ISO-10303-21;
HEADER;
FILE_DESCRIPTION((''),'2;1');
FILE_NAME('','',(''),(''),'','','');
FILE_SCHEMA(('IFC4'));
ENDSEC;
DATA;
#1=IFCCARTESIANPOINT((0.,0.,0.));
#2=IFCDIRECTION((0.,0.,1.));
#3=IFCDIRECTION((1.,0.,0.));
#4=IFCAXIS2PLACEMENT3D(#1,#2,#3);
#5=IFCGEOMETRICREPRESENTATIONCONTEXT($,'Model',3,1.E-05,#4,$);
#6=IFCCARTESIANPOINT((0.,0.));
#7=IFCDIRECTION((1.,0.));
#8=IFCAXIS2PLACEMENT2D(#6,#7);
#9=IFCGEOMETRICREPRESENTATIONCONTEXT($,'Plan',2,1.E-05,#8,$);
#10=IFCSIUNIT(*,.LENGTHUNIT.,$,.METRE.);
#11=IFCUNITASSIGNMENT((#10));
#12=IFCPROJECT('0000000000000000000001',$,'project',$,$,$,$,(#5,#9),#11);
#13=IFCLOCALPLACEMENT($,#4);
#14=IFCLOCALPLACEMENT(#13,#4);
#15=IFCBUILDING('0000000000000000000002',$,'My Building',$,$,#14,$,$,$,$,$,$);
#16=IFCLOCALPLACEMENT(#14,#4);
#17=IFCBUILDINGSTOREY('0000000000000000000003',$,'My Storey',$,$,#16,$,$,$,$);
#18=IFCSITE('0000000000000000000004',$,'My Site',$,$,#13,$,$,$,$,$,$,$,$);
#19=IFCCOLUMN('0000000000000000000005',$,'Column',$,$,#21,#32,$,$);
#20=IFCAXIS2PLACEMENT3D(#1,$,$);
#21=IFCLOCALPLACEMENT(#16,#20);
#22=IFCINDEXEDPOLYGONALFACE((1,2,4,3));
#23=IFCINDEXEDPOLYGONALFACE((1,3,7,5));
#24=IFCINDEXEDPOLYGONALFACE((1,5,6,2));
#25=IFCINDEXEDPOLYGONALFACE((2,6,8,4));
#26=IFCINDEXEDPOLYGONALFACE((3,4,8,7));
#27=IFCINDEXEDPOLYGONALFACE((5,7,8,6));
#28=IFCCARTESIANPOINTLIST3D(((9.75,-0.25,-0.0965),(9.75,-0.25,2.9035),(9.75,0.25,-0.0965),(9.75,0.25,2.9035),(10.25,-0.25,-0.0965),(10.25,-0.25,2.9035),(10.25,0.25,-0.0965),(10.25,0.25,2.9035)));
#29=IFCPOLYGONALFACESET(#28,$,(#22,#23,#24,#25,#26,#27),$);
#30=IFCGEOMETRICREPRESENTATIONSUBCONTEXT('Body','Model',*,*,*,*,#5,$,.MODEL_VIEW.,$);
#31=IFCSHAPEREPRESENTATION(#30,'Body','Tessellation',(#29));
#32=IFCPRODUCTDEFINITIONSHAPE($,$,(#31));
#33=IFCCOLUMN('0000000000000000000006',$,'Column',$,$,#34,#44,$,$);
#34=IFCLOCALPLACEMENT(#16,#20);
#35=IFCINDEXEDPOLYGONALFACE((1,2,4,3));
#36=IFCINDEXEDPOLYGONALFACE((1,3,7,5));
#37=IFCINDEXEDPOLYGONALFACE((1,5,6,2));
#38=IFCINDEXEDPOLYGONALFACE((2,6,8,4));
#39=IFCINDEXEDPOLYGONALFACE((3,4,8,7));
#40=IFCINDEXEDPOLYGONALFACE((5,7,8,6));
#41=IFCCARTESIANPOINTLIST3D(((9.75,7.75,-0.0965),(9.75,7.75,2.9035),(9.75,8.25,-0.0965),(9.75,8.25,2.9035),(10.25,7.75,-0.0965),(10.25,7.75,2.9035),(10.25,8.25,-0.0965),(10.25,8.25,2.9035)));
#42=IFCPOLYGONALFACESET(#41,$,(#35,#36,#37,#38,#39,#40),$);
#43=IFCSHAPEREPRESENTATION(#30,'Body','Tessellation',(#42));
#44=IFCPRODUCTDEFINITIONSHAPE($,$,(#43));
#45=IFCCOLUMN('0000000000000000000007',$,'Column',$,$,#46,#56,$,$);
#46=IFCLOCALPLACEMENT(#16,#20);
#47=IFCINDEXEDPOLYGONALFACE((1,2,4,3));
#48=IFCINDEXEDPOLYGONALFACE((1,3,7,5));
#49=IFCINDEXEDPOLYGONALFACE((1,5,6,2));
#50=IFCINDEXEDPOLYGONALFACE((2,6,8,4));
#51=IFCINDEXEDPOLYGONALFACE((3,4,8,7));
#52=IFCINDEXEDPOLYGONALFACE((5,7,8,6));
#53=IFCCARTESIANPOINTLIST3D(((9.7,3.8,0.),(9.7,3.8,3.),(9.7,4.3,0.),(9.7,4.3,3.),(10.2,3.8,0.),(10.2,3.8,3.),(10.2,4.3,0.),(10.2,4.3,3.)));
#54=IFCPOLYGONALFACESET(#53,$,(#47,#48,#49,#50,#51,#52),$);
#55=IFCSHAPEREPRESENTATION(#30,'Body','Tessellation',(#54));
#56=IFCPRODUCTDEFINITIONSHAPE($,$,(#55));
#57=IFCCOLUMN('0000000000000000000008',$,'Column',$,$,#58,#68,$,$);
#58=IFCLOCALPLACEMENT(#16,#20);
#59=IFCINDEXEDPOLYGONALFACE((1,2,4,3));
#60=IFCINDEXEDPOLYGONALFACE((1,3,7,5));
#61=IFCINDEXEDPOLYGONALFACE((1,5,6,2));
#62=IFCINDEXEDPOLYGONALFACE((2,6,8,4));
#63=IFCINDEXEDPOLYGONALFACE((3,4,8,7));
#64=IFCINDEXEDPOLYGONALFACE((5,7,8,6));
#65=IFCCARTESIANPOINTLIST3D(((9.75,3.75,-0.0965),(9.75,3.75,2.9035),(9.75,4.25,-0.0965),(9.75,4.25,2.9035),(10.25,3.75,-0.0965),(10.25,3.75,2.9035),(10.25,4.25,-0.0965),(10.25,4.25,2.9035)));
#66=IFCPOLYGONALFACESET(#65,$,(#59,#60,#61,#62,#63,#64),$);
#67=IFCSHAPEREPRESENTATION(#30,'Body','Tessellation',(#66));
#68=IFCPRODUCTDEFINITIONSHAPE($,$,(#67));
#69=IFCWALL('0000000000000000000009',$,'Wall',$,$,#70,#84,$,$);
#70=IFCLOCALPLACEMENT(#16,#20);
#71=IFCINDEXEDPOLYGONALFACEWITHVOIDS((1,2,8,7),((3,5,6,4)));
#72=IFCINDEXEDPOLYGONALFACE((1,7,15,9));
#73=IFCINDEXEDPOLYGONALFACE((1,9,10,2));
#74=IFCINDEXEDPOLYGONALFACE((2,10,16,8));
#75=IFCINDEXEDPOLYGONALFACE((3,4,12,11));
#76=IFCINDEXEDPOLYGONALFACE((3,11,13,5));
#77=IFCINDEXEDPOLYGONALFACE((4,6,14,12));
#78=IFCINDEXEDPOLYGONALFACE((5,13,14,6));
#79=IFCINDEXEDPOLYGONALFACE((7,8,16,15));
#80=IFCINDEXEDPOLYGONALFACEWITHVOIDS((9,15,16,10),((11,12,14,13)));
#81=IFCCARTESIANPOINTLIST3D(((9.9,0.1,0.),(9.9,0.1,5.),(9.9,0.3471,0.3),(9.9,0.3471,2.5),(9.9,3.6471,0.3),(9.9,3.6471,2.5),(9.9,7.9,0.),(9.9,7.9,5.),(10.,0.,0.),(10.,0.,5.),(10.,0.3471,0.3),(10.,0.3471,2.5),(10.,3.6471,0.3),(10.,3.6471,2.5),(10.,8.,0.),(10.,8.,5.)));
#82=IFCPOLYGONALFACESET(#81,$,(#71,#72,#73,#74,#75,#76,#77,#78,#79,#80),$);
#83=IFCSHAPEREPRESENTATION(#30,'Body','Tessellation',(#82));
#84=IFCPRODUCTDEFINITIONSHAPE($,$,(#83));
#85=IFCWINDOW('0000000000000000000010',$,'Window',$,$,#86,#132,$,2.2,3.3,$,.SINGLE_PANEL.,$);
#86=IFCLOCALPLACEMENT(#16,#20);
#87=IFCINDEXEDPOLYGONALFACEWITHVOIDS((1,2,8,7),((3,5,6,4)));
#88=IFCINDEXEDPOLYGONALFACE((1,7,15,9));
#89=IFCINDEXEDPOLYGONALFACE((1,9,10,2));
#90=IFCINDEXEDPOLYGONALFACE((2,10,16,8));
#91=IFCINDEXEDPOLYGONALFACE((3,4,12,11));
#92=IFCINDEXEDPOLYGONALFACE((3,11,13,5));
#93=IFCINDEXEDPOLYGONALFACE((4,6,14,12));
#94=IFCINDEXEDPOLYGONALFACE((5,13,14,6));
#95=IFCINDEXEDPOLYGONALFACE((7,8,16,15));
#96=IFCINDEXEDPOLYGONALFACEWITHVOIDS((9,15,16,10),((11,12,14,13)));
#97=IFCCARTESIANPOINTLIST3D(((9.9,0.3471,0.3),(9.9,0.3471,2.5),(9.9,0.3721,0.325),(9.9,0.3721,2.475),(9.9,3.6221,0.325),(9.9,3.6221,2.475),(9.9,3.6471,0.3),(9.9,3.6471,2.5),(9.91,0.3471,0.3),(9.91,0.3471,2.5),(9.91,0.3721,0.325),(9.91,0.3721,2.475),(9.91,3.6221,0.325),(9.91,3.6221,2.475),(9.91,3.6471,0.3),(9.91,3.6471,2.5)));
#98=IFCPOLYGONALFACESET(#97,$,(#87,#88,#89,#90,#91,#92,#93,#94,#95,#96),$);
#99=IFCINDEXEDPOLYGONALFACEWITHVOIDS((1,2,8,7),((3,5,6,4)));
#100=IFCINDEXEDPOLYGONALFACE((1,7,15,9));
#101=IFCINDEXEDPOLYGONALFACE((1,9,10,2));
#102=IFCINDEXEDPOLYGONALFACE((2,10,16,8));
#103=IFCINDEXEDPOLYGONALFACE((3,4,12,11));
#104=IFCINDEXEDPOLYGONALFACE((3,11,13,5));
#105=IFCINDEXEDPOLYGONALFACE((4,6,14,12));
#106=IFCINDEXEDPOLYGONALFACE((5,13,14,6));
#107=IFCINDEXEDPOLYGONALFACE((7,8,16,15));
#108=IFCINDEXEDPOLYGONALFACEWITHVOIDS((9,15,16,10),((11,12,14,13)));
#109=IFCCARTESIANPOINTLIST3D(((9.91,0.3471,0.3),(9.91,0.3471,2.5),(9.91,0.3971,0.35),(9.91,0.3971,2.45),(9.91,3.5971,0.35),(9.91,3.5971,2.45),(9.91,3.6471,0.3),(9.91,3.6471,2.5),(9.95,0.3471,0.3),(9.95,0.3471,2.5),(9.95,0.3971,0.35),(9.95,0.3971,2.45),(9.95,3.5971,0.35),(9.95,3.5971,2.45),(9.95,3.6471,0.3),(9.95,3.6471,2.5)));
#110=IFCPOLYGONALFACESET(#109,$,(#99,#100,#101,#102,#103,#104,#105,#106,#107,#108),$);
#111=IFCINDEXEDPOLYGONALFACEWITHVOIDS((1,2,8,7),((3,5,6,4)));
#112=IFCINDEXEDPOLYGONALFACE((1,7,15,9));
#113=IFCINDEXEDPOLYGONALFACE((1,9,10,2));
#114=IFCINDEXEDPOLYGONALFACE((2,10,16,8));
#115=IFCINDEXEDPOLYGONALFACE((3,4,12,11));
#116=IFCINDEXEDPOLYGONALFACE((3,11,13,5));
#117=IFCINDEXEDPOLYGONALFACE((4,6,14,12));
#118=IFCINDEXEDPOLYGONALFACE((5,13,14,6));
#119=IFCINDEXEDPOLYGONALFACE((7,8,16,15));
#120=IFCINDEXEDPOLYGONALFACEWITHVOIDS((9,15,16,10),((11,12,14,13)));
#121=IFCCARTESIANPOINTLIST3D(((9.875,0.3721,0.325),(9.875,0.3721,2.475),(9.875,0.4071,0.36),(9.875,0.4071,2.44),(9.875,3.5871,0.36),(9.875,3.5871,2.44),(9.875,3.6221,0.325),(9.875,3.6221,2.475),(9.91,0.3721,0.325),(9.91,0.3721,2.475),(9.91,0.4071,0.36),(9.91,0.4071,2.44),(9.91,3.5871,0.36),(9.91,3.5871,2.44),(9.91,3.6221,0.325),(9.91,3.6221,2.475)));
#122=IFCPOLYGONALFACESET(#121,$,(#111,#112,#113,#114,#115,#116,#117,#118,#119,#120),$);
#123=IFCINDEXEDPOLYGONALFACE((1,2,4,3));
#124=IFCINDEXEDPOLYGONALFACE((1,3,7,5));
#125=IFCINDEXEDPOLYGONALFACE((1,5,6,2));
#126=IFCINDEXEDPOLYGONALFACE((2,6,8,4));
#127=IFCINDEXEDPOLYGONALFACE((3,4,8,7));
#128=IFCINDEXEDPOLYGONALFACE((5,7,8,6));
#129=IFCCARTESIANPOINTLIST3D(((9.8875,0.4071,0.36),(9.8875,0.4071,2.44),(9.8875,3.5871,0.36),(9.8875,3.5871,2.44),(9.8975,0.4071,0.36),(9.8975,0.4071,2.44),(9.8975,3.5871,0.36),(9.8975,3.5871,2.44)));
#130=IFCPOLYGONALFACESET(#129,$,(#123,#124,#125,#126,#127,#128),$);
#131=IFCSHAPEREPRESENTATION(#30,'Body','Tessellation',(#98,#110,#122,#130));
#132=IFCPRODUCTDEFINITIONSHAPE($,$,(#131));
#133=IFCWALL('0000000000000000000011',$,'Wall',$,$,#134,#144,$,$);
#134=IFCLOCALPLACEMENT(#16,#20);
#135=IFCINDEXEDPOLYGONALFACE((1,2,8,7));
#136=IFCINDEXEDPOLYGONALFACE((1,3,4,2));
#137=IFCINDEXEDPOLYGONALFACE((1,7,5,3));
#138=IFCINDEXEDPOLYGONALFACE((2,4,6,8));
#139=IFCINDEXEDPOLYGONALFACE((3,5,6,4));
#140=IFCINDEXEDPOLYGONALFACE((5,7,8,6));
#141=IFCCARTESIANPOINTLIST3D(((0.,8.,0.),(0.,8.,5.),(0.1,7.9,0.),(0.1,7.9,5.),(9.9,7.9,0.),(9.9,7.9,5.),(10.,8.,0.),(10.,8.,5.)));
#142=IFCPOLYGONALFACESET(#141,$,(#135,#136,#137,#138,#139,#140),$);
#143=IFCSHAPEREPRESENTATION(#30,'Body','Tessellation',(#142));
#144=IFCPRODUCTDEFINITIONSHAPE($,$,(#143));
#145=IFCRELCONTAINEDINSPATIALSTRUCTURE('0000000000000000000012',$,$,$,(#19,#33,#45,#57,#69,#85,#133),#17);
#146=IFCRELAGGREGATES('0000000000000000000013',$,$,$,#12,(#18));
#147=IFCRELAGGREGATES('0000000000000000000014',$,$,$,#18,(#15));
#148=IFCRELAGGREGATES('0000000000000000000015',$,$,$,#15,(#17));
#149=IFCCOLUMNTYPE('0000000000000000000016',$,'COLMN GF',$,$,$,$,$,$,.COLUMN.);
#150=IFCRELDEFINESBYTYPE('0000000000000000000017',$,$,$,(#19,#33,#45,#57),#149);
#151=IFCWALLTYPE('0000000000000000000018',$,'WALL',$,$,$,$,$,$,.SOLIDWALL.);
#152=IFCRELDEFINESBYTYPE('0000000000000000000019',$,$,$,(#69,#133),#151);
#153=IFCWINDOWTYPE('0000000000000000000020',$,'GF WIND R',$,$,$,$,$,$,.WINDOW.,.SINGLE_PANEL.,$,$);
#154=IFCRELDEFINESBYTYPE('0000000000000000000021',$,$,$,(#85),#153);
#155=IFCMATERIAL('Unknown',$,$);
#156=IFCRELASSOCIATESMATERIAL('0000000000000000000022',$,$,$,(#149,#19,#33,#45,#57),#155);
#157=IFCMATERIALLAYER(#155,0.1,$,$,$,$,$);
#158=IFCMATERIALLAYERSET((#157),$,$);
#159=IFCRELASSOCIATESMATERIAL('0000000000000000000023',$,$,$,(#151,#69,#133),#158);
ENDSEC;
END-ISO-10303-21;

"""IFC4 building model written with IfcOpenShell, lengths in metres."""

from ifc_helpers import new_model, entity, si_unit, frame, origin_with_axes, origin_2d_with_axis, place, context, subcontext, project, spatial, line, indexed_curve, rectangle, outline, extrude, shape, source, transform, mapped, material, layer, layer_set, layer_usage, material_profile, profile_set, profile_usage, type_object, type_shapes, element, fill, save


model = new_model("IFC4")

# Units and contexts
model_context = context("Model", 3, precision=1e-05, world=origin_with_axes())
plan_context = context("Plan", 2, precision=1e-05, world=origin_2d_with_axis())
body_context_1 = subcontext(model_context, "Body", "Model", "MODEL_VIEW")
body_context_2 = subcontext(plan_context, "Body", "Plan", "PLAN_VIEW")
ifc_project = project(units=[si_unit("LENGTHUNIT", "METRE")], contexts=[model_context, plan_context])

# Site, building, storey
site_placement = place(None, origin_with_axes())
site = spatial("IfcSite", under=ifc_project, at=site_placement, Name="My Site")
building_placement = place(site_placement, origin_with_axes())
building = spatial("IfcBuilding", under=site, at=building_placement, Name="My Building")
storey_placement = place(building_placement, origin_with_axes())
storey = spatial("IfcBuildingStorey", under=building, at=storey_placement, Name="My Storey")

# Columns
ifc_material = material(Name="Unknown")
ifc_material_profile_1 = material_profile(ifc_material, rectangle(XDim=0.5, YDim=0.5))
ifc_profile_set_1 = profile_set([ifc_material_profile_1])
ifc_profile_usage_1 = profile_usage(ifc_profile_set_1, cardinal=5)
column_type = type_object("IfcColumnType", Name="COLMN GF", PredefinedType="COLUMN", material=ifc_profile_set_1)
column_1_placement = place(storey_placement, frame((10.0, 0.0, -0.0965), z_axis=(0.0, 0.0, 1.0), x_axis=(1.0, 0.0, 0.0)))
element("IfcColumn", 1, at=column_1_placement, inside=storey, type_object=column_type, material=ifc_profile_usage_1, Name="Column", context=body_context_1, shape_type="SweptSolid", body=[
    extrude(rectangle(XDim=0.5, YDim=0.5), origin_with_axes(), (0.0, 0.0, 1.0), 3.0),
])
ifc_profile_usage_2 = profile_usage(ifc_profile_set_1, cardinal=5)
column_2_placement = place(storey_placement, frame((10.0, 8.0, -0.0965), z_axis=(0.0, 0.0, 1.0), x_axis=(1.0, 0.0, 0.0)))
element("IfcColumn", 2, at=column_2_placement, inside=storey, type_object=column_type, material=ifc_profile_usage_2, Name="Column", context=body_context_1, shape_type="SweptSolid", body=[
    extrude(rectangle(XDim=0.5, YDim=0.5), origin_with_axes(), (0.0, 0.0, 1.0), 3.0),
])
ifc_profile_usage_3 = profile_usage(ifc_profile_set_1, cardinal=5)
column_3_placement = place(storey_placement, frame((9.95, 4.05, 0.0), z_axis=(0.0, 0.0, 1.0), x_axis=(1.0, 0.0, 0.0)))
element("IfcColumn", 3, at=column_3_placement, inside=storey, type_object=column_type, material=ifc_profile_usage_3, Name="Column", context=body_context_1, shape_type="SweptSolid", body=[
    extrude(rectangle(XDim=0.5, YDim=0.5), origin_with_axes(), (0.0, 0.0, 1.0), 3.0),
])
ifc_profile_usage_4 = profile_usage(ifc_profile_set_1, cardinal=5)
column_4_placement = place(storey_placement, frame((10.0, 4.0, -0.0965), z_axis=(0.0, 0.0, 1.0), x_axis=(1.0, 0.0, 0.0)))
element("IfcColumn", 4, at=column_4_placement, inside=storey, type_object=column_type, material=ifc_profile_usage_4, Name="Column", context=body_context_1, shape_type="SweptSolid", body=[
    extrude(rectangle(XDim=0.5, YDim=0.5), origin_with_axes(), (0.0, 0.0, 1.0), 3.0),
])

# Wall, opening, window
ifc_layer = layer(ifc_material, 0.1)
ifc_layer_set = layer_set([ifc_layer])
ifc_layer_usage_1 = layer_usage(ifc_layer_set, "AXIS2", "POSITIVE", 0.0)
wall_type = type_object("IfcWallType", Name="WALL", PredefinedType="SOLIDWALL", material=ifc_layer_set)
wall_1_placement = place(storey_placement, frame((10.0, 0.0, 0.0), z_axis=(0.0, 0.0, 1.0), x_axis=(0.0, 1.0, 0.0)))
wall_1 = element("IfcWall", 5, at=wall_1_placement, inside=storey, type_object=wall_type, material=ifc_layer_usage_1, Name="Wall", context=body_context_1, shape_type="SweptSolid", body=[
    extrude(outline(indexed_curve([(0.0, 0.0), (0.1, 0.1), (7.9, 0.1), (8.0, 0.0)], segments=[line(1, 2, 3, 4, 1)])), origin_with_axes(), (0.0, 0.0, 1.0), 5.0),
])
shared_shape_1 = source(origin_with_axes(), body_context_1, "Body", "SweptSolid", [
    extrude(outline(indexed_curve([(0.0, 0.0), (3.3, 0.0), (3.3, 2.2), (0.0, 2.2)], segments=[line(1, 2, 3, 4, 1)])), frame((0.0, -0.6, 0.0), z_axis=(0.0, -1.0, 0.0), x_axis=(1.0, 0.0, 0.0)), (0.0, 0.0, -1.0), 1.2),
])
opening_1_placement = place(wall_1_placement, frame((0.3471, 0.0, 0.3), z_axis=(0.0, 0.0, 1.0), x_axis=(1.0, 0.0, 0.0)))
opening_1 = element("IfcOpeningElement", 6, at=opening_1_placement, cuts=wall_1, PredefinedType="OPENING", context=body_context_1, shape_type="MappedRepresentation", body=[
    mapped(shared_shape_1, transform((0.0, 0.0, 0.0), x_axis=(1.0, 0.0, 0.0), y_axis=(0.0, 1.0, 0.0), z_axis=(0.0, 0.0, 1.0), scale=1.0)),
])
window_type = type_object("IfcWindowType", Name="GF WIND R", PartitioningType="SINGLE_PANEL", PredefinedType="WINDOW")
shared_shape_2 = source(origin_with_axes(), body_context_1, "Body", "SweptSolid", [
    extrude(outline(indexed_curve([(0.0, 0.0), (3.3, 0.0), (3.3, 2.2), (0.0, 2.2)], segments=[line(1, 2, 3, 4, 1)]), holes=[indexed_curve([(0.025, 0.025), (3.275, 0.025), (3.275, 2.175), (0.025, 2.175)], segments=[line(1, 2, 3, 4, 1)])]), frame((0.0, 0.09, 0.0), z_axis=(0.0, -1.0, 0.0), x_axis=(1.0, 0.0, 0.0)), (0.0, 0.0, -1.0), 0.01),
    extrude(outline(indexed_curve([(0.0, 0.0), (3.3, 0.0), (3.3, 2.2), (0.0, 2.2)], segments=[line(1, 2, 3, 4, 1)]), holes=[indexed_curve([(0.05, 0.05), (3.25, 0.05), (3.25, 2.15), (0.05, 2.15)], segments=[line(1, 2, 3, 4, 1)])]), frame((0.0, 0.05, 0.0), z_axis=(0.0, -1.0, 0.0), x_axis=(1.0, 0.0, 0.0)), (0.0, 0.0, -1.0), 0.04),
    extrude(outline(indexed_curve([(0.0, 0.0), (3.25, 0.0), (3.25, 2.15), (0.0, 2.15)], segments=[line(1, 2, 3, 4, 1)]), holes=[indexed_curve([(0.035, 0.035), (3.215, 0.035), (3.215, 2.115), (0.035, 2.115)], segments=[line(1, 2, 3, 4, 1)])]), frame((0.025, 0.09, 0.025), z_axis=(0.0, -1.0, 0.0), x_axis=(1.0, 0.0, 0.0)), (0.0, 0.0, -1.0), 0.035),
    extrude(outline(indexed_curve([(0.035, 0.035), (3.215, 0.035), (3.215, 2.115), (0.035, 2.115)], segments=[line(1, 2, 3, 4, 1)])), frame((0.025, 0.1025, 0.025), z_axis=(0.0, -1.0, 0.0), x_axis=(1.0, 0.0, 0.0)), (0.0, 0.0, -1.0), 0.01),
])
shared_shape_3 = source(origin_with_axes(), body_context_2, "Body", "Curve2D", [
    entity("IfcIndexedPolyCurve", entity("IfcCartesianPointList2D", [[0.05, 0.05], [3.25, 0.05]])),
    entity("IfcIndexedPolyCurve", entity("IfcCartesianPointList2D", [[0.0, 0.1], [0.025, 0.1], [0.025, 0.09], [0.05, 0.09], [0.05, 0.05], [0.0, 0.05]]), [entity("IfcLineIndex", [1, 2, 3, 4, 5, 6, 1])]),
    entity("IfcIndexedPolyCurve", entity("IfcCartesianPointList2D", [[3.3, 0.1], [3.275, 0.1], [3.275, 0.09], [3.25, 0.09], [3.25, 0.05], [3.3, 0.05]]), [entity("IfcLineIndex", [1, 2, 3, 4, 5, 6, 1])]),
    entity("IfcIndexedPolyCurve", entity("IfcCartesianPointList2D", [[0.025, 0.09], [0.06, 0.09], [0.06, 0.125], [0.025, 0.125]]), [entity("IfcLineIndex", [1, 2, 3, 4, 1])]),
    entity("IfcIndexedPolyCurve", entity("IfcCartesianPointList2D", [[3.275, 0.09], [3.24, 0.09], [3.24, 0.125], [3.275, 0.125]]), [entity("IfcLineIndex", [1, 2, 3, 4, 1])]),
    entity("IfcIndexedPolyCurve", entity("IfcCartesianPointList2D", [[0.06, 0.09], [3.24, 0.09]])),
    entity("IfcIndexedPolyCurve", entity("IfcCartesianPointList2D", [[0.06, 0.125], [3.24, 0.125]])),
    entity("IfcIndexedPolyCurve", entity("IfcCartesianPointList2D", [[0.06, 0.1075], [3.24, 0.1075]])),
])
type_shapes(window_type, [shared_shape_2, shared_shape_3])
window_placement = place(opening_1_placement, frame((0.0, 0.0, 0.0), z_axis=(0.0, 0.0, 1.0), x_axis=(1.0, 0.0, 0.0)))
window = element("IfcWindow", 7, at=window_placement, inside=storey, type_object=window_type, Name="Window", OverallHeight=2.2, OverallWidth=3.3, PartitioningType="SINGLE_PANEL", shapes=[
    shape(body_context_1, "Body", "MappedRepresentation", [mapped(shared_shape_2, transform((0.0, 0.0, 0.0), x_axis=(1.0, 0.0, 0.0), y_axis=(0.0, 1.0, 0.0), z_axis=(0.0, 0.0, 1.0), scale=1.0))]),
    shape(body_context_2, "Body", "MappedRepresentation", [mapped(shared_shape_3, transform((0.0, 0.0, 0.0), x_axis=(1.0, 0.0, 0.0), y_axis=(0.0, 1.0, 0.0), z_axis=(0.0, 0.0, 1.0), scale=1.0))]),
])
fill(opening_1, window)

# Wall
ifc_layer_usage_2 = layer_usage(ifc_layer_set, "AXIS2", "POSITIVE", 0.0)
wall_2_placement = place(storey_placement, frame((10.0, 8.0, 0.0), z_axis=(0.0, 0.0, 1.0), x_axis=(-1.0, 0.0, 0.0)))
element("IfcWall", 8, at=wall_2_placement, inside=storey, type_object=wall_type, material=ifc_layer_usage_2, Name="Wall", context=body_context_1, shape_type="SweptSolid", body=[
    extrude(outline(indexed_curve([(0.0, 0.0), (0.1, 0.1), (9.9, 0.1), (10.0, 0.0)], segments=[line(1, 2, 3, 4, 1)])), origin_with_axes(), (0.0, 0.0, 1.0), 5.0),
])

save(model, "model.ifc")
